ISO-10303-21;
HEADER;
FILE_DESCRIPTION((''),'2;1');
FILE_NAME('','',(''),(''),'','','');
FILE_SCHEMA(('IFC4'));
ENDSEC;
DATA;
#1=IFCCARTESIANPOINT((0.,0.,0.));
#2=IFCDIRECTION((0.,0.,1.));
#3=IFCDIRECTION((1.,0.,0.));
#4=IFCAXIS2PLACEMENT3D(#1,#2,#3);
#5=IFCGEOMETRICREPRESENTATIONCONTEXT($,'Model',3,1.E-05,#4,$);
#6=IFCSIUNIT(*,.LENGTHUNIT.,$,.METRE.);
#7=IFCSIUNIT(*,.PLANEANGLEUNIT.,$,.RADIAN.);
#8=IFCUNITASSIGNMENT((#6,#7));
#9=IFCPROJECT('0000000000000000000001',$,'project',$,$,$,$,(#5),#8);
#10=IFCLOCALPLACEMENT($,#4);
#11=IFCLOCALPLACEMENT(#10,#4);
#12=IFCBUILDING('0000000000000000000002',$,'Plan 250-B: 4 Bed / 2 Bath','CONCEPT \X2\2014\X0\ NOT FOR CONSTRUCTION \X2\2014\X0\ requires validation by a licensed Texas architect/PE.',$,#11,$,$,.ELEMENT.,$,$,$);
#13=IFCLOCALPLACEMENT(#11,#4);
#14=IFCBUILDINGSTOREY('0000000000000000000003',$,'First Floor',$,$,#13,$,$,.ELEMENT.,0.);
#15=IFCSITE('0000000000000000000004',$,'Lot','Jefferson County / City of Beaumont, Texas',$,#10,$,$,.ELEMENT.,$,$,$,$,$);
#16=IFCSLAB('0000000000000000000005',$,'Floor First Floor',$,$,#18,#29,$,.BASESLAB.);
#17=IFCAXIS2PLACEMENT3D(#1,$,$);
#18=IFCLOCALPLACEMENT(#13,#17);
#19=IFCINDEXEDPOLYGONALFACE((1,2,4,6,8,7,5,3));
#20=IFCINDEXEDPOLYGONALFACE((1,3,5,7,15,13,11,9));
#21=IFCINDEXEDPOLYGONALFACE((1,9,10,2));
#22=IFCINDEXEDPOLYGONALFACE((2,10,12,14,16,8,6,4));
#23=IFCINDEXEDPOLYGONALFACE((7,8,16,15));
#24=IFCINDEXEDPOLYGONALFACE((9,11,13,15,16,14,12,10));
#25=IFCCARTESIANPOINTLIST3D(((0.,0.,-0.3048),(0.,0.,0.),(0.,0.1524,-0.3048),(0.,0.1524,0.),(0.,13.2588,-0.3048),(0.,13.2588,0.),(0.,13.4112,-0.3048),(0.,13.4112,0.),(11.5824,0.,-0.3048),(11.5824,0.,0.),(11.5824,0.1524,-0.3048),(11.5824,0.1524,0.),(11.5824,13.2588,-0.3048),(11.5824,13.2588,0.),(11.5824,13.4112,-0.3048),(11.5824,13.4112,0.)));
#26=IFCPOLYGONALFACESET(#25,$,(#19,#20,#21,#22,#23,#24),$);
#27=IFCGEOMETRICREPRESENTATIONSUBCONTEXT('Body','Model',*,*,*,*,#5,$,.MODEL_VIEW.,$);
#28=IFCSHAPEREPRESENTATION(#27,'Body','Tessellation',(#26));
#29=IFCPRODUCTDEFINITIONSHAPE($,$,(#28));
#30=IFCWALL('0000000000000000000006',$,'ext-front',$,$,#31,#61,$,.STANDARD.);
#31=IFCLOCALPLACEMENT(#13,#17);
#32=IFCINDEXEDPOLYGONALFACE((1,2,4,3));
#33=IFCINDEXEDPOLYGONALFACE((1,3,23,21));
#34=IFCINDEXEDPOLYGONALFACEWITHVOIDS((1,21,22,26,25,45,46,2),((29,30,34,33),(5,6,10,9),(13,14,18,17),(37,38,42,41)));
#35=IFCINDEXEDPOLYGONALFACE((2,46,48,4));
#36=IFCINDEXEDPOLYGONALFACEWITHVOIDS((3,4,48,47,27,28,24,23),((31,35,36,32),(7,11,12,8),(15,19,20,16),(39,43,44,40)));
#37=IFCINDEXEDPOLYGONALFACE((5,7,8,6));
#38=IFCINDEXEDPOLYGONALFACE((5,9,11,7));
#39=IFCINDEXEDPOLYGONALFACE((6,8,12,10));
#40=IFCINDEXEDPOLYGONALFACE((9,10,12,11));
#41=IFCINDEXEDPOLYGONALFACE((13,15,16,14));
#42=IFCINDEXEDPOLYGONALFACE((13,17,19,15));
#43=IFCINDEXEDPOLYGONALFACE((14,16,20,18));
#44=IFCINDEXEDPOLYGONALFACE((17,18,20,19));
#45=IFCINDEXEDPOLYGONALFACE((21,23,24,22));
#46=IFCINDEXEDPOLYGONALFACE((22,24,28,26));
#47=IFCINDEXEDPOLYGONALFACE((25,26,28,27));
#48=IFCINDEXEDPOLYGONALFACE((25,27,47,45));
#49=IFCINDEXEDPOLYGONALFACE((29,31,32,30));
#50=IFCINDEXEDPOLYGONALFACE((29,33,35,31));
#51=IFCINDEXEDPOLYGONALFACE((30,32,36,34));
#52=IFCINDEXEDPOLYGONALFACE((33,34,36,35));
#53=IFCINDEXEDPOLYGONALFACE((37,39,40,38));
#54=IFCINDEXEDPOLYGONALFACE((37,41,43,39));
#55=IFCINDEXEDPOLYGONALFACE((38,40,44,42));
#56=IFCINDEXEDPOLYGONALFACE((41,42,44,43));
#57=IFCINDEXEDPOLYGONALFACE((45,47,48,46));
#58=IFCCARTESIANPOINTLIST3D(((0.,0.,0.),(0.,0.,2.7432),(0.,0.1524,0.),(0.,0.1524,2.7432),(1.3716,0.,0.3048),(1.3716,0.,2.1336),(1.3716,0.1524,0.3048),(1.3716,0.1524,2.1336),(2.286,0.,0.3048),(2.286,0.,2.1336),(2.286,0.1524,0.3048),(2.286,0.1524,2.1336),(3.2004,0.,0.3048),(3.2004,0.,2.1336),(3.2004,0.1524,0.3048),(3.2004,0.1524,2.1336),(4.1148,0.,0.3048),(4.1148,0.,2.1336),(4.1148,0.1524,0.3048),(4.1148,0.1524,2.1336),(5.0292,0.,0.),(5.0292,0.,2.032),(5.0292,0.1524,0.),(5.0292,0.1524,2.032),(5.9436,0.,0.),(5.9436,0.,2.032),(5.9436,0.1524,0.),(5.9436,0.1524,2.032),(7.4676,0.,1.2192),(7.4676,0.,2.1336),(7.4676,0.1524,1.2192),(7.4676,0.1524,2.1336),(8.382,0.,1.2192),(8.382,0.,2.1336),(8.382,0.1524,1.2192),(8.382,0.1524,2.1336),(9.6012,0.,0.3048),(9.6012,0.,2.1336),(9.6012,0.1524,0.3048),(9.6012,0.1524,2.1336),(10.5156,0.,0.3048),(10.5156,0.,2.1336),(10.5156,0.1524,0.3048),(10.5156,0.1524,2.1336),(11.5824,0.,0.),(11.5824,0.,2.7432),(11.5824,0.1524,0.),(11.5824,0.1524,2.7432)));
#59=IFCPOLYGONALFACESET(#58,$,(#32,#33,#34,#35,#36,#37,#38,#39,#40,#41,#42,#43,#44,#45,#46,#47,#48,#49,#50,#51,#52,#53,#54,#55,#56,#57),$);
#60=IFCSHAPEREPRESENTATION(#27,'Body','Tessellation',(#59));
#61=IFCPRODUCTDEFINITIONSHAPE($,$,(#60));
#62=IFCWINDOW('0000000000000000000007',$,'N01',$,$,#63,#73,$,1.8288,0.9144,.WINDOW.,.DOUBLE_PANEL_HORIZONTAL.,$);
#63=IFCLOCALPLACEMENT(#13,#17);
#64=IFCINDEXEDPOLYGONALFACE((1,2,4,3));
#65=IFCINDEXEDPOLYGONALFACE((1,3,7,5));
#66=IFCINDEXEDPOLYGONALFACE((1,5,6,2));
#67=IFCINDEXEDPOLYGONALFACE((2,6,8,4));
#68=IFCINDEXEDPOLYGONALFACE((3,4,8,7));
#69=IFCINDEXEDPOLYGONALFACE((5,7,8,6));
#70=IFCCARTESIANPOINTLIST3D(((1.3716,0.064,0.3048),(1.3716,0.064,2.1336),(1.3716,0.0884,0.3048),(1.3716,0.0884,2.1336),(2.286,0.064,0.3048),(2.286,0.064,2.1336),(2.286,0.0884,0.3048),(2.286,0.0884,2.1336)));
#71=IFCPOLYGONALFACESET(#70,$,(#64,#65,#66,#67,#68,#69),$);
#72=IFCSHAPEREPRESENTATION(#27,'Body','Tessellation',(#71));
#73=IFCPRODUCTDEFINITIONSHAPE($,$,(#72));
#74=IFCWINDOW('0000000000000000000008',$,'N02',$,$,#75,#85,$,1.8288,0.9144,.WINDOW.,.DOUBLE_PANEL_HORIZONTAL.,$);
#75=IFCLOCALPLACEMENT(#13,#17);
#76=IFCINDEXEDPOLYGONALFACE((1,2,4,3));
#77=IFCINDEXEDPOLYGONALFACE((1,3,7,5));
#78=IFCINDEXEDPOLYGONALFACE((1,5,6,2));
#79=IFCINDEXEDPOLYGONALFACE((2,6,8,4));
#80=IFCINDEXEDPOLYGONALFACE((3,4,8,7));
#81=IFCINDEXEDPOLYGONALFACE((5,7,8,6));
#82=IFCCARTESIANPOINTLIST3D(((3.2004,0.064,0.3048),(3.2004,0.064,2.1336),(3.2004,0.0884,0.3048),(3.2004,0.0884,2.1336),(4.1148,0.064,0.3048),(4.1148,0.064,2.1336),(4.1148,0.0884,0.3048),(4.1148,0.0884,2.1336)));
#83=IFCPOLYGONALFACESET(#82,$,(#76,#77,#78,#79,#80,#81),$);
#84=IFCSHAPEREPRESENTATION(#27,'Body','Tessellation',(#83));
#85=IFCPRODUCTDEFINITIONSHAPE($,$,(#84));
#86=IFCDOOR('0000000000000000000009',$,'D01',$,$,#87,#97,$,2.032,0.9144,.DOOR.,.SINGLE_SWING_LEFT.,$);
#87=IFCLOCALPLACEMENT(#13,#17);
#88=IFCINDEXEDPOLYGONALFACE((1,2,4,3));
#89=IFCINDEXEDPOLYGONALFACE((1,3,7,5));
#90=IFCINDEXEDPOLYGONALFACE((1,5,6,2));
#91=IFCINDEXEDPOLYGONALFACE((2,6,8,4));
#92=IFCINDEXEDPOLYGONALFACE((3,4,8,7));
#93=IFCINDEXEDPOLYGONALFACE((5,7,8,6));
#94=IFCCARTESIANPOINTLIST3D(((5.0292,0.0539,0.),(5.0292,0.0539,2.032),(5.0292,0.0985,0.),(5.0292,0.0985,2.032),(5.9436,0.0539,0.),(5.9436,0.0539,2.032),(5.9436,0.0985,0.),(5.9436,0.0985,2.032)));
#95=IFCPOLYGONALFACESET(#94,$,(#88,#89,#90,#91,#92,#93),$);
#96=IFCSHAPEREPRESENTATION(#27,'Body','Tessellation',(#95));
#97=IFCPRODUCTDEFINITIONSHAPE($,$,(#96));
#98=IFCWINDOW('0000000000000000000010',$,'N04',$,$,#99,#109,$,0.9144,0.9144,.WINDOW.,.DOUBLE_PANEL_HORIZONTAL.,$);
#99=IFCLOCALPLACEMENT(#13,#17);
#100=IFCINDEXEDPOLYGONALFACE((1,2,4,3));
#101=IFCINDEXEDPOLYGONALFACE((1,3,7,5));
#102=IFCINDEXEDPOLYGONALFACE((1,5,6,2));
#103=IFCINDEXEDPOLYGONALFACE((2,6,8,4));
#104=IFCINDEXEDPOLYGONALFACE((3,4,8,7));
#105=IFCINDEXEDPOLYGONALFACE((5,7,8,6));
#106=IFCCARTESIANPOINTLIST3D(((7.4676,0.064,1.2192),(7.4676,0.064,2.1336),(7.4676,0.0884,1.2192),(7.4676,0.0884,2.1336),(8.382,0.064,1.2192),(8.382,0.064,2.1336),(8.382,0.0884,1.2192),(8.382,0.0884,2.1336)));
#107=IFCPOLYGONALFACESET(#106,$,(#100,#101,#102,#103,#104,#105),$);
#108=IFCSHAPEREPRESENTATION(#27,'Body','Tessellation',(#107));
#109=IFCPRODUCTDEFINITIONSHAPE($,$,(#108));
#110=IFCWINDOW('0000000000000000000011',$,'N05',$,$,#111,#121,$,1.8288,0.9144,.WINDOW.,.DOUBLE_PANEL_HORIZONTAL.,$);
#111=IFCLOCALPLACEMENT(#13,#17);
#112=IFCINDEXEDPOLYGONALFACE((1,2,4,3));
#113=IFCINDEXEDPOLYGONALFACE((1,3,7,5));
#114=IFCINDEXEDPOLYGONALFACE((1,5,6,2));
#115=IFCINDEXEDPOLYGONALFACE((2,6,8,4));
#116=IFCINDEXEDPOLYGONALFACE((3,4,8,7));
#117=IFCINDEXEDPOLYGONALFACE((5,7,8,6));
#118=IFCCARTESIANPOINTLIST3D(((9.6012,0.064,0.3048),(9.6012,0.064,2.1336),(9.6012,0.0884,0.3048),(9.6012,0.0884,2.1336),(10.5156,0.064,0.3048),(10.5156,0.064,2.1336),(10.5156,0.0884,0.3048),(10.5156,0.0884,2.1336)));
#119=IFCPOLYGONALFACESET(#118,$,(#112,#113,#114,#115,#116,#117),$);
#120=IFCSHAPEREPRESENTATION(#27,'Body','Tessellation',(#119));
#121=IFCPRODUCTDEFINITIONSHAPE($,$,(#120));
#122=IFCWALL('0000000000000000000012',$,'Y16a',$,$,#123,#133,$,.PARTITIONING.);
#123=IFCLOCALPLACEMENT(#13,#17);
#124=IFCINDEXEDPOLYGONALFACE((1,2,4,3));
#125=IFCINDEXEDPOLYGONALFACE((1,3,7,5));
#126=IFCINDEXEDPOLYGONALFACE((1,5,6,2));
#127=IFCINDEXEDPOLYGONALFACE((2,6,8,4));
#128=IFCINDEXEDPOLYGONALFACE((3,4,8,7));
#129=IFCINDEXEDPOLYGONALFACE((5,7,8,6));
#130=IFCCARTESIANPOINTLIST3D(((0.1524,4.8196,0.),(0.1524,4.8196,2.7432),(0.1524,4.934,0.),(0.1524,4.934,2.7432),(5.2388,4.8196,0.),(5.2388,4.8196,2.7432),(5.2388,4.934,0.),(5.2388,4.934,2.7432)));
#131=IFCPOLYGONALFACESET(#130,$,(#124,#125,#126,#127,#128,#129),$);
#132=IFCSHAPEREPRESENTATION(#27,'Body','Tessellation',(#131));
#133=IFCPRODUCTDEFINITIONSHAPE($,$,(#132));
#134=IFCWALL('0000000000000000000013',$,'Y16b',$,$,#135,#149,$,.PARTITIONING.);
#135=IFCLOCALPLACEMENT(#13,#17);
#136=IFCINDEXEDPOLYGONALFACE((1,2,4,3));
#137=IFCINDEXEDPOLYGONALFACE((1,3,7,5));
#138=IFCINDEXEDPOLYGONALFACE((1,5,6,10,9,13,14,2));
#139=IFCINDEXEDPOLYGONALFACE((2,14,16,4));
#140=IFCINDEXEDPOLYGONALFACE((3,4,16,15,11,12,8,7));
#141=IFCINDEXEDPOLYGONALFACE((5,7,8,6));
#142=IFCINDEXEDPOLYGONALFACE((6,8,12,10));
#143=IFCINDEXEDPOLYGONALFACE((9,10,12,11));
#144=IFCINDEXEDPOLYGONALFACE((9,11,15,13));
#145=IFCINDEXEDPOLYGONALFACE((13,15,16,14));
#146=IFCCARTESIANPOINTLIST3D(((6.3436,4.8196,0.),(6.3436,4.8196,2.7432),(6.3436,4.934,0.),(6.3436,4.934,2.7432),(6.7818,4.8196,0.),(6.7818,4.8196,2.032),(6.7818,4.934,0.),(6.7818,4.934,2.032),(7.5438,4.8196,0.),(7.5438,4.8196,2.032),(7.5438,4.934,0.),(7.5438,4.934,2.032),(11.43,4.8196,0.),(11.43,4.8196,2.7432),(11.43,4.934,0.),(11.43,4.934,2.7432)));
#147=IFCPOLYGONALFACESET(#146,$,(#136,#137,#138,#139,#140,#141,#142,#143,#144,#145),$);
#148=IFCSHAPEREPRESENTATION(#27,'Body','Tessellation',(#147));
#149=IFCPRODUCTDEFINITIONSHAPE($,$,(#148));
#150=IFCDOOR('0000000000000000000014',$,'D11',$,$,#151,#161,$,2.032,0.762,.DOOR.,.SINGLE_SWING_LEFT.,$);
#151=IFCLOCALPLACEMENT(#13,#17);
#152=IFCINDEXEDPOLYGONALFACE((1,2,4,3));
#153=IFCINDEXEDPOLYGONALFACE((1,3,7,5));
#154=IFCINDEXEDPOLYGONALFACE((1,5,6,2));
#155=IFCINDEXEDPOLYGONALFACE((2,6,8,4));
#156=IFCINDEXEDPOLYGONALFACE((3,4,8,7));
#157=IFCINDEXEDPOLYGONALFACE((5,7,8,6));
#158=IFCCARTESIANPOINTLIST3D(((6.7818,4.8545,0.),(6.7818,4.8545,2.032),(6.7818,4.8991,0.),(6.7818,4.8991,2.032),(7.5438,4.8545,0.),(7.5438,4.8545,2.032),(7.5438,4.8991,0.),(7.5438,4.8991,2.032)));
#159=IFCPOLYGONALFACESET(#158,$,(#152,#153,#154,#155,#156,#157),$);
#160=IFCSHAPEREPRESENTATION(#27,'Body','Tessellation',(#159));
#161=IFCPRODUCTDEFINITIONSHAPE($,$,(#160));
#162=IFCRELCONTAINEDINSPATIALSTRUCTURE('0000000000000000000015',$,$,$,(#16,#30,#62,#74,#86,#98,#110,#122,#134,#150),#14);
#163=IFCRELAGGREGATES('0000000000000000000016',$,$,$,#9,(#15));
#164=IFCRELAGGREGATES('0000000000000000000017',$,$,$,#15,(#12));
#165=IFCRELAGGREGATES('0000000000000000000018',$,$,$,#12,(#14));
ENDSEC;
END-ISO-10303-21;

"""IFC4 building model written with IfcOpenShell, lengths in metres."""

from ifc_helpers import new_model, si_unit, frame, frame_2d, origin_with_axes, place, context, subcontext, project, spatial, polyline, rectangle, outline, extrude, element, fill, save


model = new_model("IFC4")

# Units and contexts
model_context = context("Model", 3, precision=1e-05, world=origin_with_axes())
body_context = subcontext(model_context, "Body", "Model", "MODEL_VIEW")
ifc_project = project(units=[si_unit("LENGTHUNIT", "METRE"), si_unit("PLANEANGLEUNIT", "RADIAN")], contexts=[model_context])

# Site, building, storey
site_placement = place(None, origin_with_axes())
site = spatial("IfcSite", under=ifc_project, at=site_placement, Name="Lot", Description="Jefferson County / City of Beaumont, Texas", CompositionType="ELEMENT")
building_placement = place(site_placement, origin_with_axes())
building = spatial("IfcBuilding", under=site, at=building_placement, Name="Plan 250-B: 4 Bed / 2 Bath", Description="CONCEPT — NOT FOR CONSTRUCTION — requires validation by a licensed Texas architect/PE.", CompositionType="ELEMENT")
storey_placement = place(building_placement, origin_with_axes())
storey = spatial("IfcBuildingStorey", under=building, at=storey_placement, Name="First Floor", CompositionType="ELEMENT", Elevation=0.0)

# Slab
slab_placement = place(storey_placement, frame((0.0, 0.0, -0.3048), z_axis=(0.0, 0.0, 1.0), x_axis=(1.0, 0.0, 0.0)))
element("IfcSlab", 1, at=slab_placement, inside=storey, Name="Floor First Floor", PredefinedType="BASESLAB", context=body_context, shape_type="SweptSolid", body=[
    extrude(outline(polyline([(11.5824, 13.4112), (11.5824, 13.2588), (11.5824, 0.1524), (11.5824, 0.0), (0.0, 0.0), (0.0, 0.1524), (0.0, 13.2588), (0.0, 13.4112), (11.5824, 13.4112)])), origin_with_axes(), (0.0, 0.0, 1.0), 0.3048),
])

# Wall, openings, windows, door
wall_1_placement = place(storey_placement, frame((0.0, 0.0762, 0.0), z_axis=(0.0, 0.0, 1.0), x_axis=(1.0, 0.0, 0.0)))
wall_1 = element("IfcWall", 2, at=wall_1_placement, inside=storey, Name="ext-front", PredefinedType="STANDARD", context=body_context, shape_type="SweptSolid", body=[
    extrude(rectangle(XDim=11.5824, YDim=0.1524, at=frame_2d((5.7912, 0.0), x_axis=(1.0, 0.0))), origin_with_axes(), (0.0, 0.0, 1.0), 2.7432),
])
opening_1_placement = place(wall_1_placement, frame((1.3716, 0.0, 0.3048), z_axis=(0.0, 0.0, 1.0), x_axis=(1.0, 0.0, 0.0)))
opening_1 = element("IfcOpeningElement", 3, at=opening_1_placement, cuts=wall_1, PredefinedType="OPENING", context=body_context, shape_type="SweptSolid", body=[
    extrude(rectangle(XDim=0.9144, YDim=0.1829, at=frame_2d((0.4572, 0.0), x_axis=(1.0, 0.0))), origin_with_axes(), (0.0, 0.0, 1.0), 1.8288),
])
opening_2_placement = place(wall_1_placement, frame((3.2004, 0.0, 0.3048), z_axis=(0.0, 0.0, 1.0), x_axis=(1.0, 0.0, 0.0)))
opening_2 = element("IfcOpeningElement", 4, at=opening_2_placement, cuts=wall_1, PredefinedType="OPENING", context=body_context, shape_type="SweptSolid", body=[
    extrude(rectangle(XDim=0.9144, YDim=0.1829, at=frame_2d((0.4572, 0.0), x_axis=(1.0, 0.0))), origin_with_axes(), (0.0, 0.0, 1.0), 1.8288),
])
opening_3_placement = place(wall_1_placement, frame((5.0292, 0.0, 0.0), z_axis=(0.0, 0.0, 1.0), x_axis=(1.0, 0.0, 0.0)))
opening_3 = element("IfcOpeningElement", 5, at=opening_3_placement, cuts=wall_1, PredefinedType="OPENING", context=body_context, shape_type="SweptSolid", body=[
    extrude(rectangle(XDim=0.9144, YDim=0.1829, at=frame_2d((0.4572, 0.0), x_axis=(1.0, 0.0))), origin_with_axes(), (0.0, 0.0, 1.0), 2.032),
])
opening_4_placement = place(wall_1_placement, frame((7.4676, 0.0, 1.2192), z_axis=(0.0, 0.0, 1.0), x_axis=(1.0, 0.0, 0.0)))
opening_4 = element("IfcOpeningElement", 6, at=opening_4_placement, cuts=wall_1, PredefinedType="OPENING", context=body_context, shape_type="SweptSolid", body=[
    extrude(rectangle(XDim=0.9144, YDim=0.1829, at=frame_2d((0.4572, 0.0), x_axis=(1.0, 0.0))), origin_with_axes(), (0.0, 0.0, 1.0), 0.9144),
])
opening_5_placement = place(wall_1_placement, frame((9.6012, 0.0, 0.3048), z_axis=(0.0, 0.0, 1.0), x_axis=(1.0, 0.0, 0.0)))
opening_5 = element("IfcOpeningElement", 7, at=opening_5_placement, cuts=wall_1, PredefinedType="OPENING", context=body_context, shape_type="SweptSolid", body=[
    extrude(rectangle(XDim=0.9144, YDim=0.1829, at=frame_2d((0.4572, 0.0), x_axis=(1.0, 0.0))), origin_with_axes(), (0.0, 0.0, 1.0), 1.8288),
])
window_1_placement = place(opening_1_placement, origin_with_axes())
window_1 = element("IfcWindow", 8, at=window_1_placement, inside=storey, Name="N01", OverallHeight=1.8288, OverallWidth=0.9144, PartitioningType="DOUBLE_PANEL_HORIZONTAL", PredefinedType="WINDOW", context=body_context, shape_type="SweptSolid", body=[
    extrude(rectangle(XDim=0.9144, YDim=0.0244, at=frame_2d((0.4572, 0.0), x_axis=(1.0, 0.0))), origin_with_axes(), (0.0, 0.0, 1.0), 1.8288),
])
fill(opening_1, window_1)
window_2_placement = place(opening_2_placement, origin_with_axes())
window_2 = element("IfcWindow", 9, at=window_2_placement, inside=storey, Name="N02", OverallHeight=1.8288, OverallWidth=0.9144, PartitioningType="DOUBLE_PANEL_HORIZONTAL", PredefinedType="WINDOW", context=body_context, shape_type="SweptSolid", body=[
    extrude(rectangle(XDim=0.9144, YDim=0.0244, at=frame_2d((0.4572, 0.0), x_axis=(1.0, 0.0))), origin_with_axes(), (0.0, 0.0, 1.0), 1.8288),
])
fill(opening_2, window_2)
door_1_placement = place(opening_3_placement, origin_with_axes())
door_1 = element("IfcDoor", 10, at=door_1_placement, inside=storey, Name="D01", OperationType="SINGLE_SWING_LEFT", OverallHeight=2.032, OverallWidth=0.9144, PredefinedType="DOOR", context=body_context, shape_type="SweptSolid", body=[
    extrude(rectangle(XDim=0.9144, YDim=0.0445, at=frame_2d((0.4572, 0.0), x_axis=(1.0, 0.0))), origin_with_axes(), (0.0, 0.0, 1.0), 2.032),
])
fill(opening_3, door_1)
window_3_placement = place(opening_4_placement, origin_with_axes())
window_3 = element("IfcWindow", 11, at=window_3_placement, inside=storey, Name="N04", OverallHeight=0.9144, OverallWidth=0.9144, PartitioningType="DOUBLE_PANEL_HORIZONTAL", PredefinedType="WINDOW", context=body_context, shape_type="SweptSolid", body=[
    extrude(rectangle(XDim=0.9144, YDim=0.0244, at=frame_2d((0.4572, 0.0), x_axis=(1.0, 0.0))), origin_with_axes(), (0.0, 0.0, 1.0), 0.9144),
])
fill(opening_4, window_3)
window_4_placement = place(opening_5_placement, origin_with_axes())
window_4 = element("IfcWindow", 12, at=window_4_placement, inside=storey, Name="N05", OverallHeight=1.8288, OverallWidth=0.9144, PartitioningType="DOUBLE_PANEL_HORIZONTAL", PredefinedType="WINDOW", context=body_context, shape_type="SweptSolid", body=[
    extrude(rectangle(XDim=0.9144, YDim=0.0244, at=frame_2d((0.4572, 0.0), x_axis=(1.0, 0.0))), origin_with_axes(), (0.0, 0.0, 1.0), 1.8288),
])
fill(opening_5, window_4)

# Wall
wall_2_placement = place(storey_placement, frame((0.1524, 4.8768, 0.0), z_axis=(0.0, 0.0, 1.0), x_axis=(1.0, 0.0, 0.0)))
element("IfcWall", 13, at=wall_2_placement, inside=storey, Name="Y16a", PredefinedType="PARTITIONING", context=body_context, shape_type="SweptSolid", body=[
    extrude(rectangle(XDim=5.0864, YDim=0.1143, at=frame_2d((2.5432, 0.0), x_axis=(1.0, 0.0))), origin_with_axes(), (0.0, 0.0, 1.0), 2.7432),
])

# Wall, opening, door
wall_3_placement = place(storey_placement, frame((6.3437, 4.8768, 0.0), z_axis=(0.0, 0.0, 1.0), x_axis=(1.0, 0.0, 0.0)))
wall_3 = element("IfcWall", 14, at=wall_3_placement, inside=storey, Name="Y16b", PredefinedType="PARTITIONING", context=body_context, shape_type="SweptSolid", body=[
    extrude(rectangle(XDim=5.0864, YDim=0.1143, at=frame_2d((2.5432, 0.0), x_axis=(1.0, 0.0))), origin_with_axes(), (0.0, 0.0, 1.0), 2.7432),
])
opening_6_placement = place(wall_3_placement, frame((0.4382, 0.0, 0.0), z_axis=(0.0, 0.0, 1.0), x_axis=(1.0, 0.0, 0.0)))
opening_6 = element("IfcOpeningElement", 15, at=opening_6_placement, cuts=wall_3, PredefinedType="OPENING", context=body_context, shape_type="SweptSolid", body=[
    extrude(rectangle(XDim=0.762, YDim=0.1448, at=frame_2d((0.381, 0.0), x_axis=(1.0, 0.0))), origin_with_axes(), (0.0, 0.0, 1.0), 2.032),
])
door_2_placement = place(opening_6_placement, origin_with_axes())
door_2 = element("IfcDoor", 16, at=door_2_placement, inside=storey, Name="D11", OperationType="SINGLE_SWING_LEFT", OverallHeight=2.032, OverallWidth=0.762, PredefinedType="DOOR", context=body_context, shape_type="SweptSolid", body=[
    extrude(rectangle(XDim=0.762, YDim=0.0445, at=frame_2d((0.381, 0.0), x_axis=(1.0, 0.0))), origin_with_axes(), (0.0, 0.0, 1.0), 2.032),
])
fill(opening_6, door_2)

save(model, "model.ifc")
